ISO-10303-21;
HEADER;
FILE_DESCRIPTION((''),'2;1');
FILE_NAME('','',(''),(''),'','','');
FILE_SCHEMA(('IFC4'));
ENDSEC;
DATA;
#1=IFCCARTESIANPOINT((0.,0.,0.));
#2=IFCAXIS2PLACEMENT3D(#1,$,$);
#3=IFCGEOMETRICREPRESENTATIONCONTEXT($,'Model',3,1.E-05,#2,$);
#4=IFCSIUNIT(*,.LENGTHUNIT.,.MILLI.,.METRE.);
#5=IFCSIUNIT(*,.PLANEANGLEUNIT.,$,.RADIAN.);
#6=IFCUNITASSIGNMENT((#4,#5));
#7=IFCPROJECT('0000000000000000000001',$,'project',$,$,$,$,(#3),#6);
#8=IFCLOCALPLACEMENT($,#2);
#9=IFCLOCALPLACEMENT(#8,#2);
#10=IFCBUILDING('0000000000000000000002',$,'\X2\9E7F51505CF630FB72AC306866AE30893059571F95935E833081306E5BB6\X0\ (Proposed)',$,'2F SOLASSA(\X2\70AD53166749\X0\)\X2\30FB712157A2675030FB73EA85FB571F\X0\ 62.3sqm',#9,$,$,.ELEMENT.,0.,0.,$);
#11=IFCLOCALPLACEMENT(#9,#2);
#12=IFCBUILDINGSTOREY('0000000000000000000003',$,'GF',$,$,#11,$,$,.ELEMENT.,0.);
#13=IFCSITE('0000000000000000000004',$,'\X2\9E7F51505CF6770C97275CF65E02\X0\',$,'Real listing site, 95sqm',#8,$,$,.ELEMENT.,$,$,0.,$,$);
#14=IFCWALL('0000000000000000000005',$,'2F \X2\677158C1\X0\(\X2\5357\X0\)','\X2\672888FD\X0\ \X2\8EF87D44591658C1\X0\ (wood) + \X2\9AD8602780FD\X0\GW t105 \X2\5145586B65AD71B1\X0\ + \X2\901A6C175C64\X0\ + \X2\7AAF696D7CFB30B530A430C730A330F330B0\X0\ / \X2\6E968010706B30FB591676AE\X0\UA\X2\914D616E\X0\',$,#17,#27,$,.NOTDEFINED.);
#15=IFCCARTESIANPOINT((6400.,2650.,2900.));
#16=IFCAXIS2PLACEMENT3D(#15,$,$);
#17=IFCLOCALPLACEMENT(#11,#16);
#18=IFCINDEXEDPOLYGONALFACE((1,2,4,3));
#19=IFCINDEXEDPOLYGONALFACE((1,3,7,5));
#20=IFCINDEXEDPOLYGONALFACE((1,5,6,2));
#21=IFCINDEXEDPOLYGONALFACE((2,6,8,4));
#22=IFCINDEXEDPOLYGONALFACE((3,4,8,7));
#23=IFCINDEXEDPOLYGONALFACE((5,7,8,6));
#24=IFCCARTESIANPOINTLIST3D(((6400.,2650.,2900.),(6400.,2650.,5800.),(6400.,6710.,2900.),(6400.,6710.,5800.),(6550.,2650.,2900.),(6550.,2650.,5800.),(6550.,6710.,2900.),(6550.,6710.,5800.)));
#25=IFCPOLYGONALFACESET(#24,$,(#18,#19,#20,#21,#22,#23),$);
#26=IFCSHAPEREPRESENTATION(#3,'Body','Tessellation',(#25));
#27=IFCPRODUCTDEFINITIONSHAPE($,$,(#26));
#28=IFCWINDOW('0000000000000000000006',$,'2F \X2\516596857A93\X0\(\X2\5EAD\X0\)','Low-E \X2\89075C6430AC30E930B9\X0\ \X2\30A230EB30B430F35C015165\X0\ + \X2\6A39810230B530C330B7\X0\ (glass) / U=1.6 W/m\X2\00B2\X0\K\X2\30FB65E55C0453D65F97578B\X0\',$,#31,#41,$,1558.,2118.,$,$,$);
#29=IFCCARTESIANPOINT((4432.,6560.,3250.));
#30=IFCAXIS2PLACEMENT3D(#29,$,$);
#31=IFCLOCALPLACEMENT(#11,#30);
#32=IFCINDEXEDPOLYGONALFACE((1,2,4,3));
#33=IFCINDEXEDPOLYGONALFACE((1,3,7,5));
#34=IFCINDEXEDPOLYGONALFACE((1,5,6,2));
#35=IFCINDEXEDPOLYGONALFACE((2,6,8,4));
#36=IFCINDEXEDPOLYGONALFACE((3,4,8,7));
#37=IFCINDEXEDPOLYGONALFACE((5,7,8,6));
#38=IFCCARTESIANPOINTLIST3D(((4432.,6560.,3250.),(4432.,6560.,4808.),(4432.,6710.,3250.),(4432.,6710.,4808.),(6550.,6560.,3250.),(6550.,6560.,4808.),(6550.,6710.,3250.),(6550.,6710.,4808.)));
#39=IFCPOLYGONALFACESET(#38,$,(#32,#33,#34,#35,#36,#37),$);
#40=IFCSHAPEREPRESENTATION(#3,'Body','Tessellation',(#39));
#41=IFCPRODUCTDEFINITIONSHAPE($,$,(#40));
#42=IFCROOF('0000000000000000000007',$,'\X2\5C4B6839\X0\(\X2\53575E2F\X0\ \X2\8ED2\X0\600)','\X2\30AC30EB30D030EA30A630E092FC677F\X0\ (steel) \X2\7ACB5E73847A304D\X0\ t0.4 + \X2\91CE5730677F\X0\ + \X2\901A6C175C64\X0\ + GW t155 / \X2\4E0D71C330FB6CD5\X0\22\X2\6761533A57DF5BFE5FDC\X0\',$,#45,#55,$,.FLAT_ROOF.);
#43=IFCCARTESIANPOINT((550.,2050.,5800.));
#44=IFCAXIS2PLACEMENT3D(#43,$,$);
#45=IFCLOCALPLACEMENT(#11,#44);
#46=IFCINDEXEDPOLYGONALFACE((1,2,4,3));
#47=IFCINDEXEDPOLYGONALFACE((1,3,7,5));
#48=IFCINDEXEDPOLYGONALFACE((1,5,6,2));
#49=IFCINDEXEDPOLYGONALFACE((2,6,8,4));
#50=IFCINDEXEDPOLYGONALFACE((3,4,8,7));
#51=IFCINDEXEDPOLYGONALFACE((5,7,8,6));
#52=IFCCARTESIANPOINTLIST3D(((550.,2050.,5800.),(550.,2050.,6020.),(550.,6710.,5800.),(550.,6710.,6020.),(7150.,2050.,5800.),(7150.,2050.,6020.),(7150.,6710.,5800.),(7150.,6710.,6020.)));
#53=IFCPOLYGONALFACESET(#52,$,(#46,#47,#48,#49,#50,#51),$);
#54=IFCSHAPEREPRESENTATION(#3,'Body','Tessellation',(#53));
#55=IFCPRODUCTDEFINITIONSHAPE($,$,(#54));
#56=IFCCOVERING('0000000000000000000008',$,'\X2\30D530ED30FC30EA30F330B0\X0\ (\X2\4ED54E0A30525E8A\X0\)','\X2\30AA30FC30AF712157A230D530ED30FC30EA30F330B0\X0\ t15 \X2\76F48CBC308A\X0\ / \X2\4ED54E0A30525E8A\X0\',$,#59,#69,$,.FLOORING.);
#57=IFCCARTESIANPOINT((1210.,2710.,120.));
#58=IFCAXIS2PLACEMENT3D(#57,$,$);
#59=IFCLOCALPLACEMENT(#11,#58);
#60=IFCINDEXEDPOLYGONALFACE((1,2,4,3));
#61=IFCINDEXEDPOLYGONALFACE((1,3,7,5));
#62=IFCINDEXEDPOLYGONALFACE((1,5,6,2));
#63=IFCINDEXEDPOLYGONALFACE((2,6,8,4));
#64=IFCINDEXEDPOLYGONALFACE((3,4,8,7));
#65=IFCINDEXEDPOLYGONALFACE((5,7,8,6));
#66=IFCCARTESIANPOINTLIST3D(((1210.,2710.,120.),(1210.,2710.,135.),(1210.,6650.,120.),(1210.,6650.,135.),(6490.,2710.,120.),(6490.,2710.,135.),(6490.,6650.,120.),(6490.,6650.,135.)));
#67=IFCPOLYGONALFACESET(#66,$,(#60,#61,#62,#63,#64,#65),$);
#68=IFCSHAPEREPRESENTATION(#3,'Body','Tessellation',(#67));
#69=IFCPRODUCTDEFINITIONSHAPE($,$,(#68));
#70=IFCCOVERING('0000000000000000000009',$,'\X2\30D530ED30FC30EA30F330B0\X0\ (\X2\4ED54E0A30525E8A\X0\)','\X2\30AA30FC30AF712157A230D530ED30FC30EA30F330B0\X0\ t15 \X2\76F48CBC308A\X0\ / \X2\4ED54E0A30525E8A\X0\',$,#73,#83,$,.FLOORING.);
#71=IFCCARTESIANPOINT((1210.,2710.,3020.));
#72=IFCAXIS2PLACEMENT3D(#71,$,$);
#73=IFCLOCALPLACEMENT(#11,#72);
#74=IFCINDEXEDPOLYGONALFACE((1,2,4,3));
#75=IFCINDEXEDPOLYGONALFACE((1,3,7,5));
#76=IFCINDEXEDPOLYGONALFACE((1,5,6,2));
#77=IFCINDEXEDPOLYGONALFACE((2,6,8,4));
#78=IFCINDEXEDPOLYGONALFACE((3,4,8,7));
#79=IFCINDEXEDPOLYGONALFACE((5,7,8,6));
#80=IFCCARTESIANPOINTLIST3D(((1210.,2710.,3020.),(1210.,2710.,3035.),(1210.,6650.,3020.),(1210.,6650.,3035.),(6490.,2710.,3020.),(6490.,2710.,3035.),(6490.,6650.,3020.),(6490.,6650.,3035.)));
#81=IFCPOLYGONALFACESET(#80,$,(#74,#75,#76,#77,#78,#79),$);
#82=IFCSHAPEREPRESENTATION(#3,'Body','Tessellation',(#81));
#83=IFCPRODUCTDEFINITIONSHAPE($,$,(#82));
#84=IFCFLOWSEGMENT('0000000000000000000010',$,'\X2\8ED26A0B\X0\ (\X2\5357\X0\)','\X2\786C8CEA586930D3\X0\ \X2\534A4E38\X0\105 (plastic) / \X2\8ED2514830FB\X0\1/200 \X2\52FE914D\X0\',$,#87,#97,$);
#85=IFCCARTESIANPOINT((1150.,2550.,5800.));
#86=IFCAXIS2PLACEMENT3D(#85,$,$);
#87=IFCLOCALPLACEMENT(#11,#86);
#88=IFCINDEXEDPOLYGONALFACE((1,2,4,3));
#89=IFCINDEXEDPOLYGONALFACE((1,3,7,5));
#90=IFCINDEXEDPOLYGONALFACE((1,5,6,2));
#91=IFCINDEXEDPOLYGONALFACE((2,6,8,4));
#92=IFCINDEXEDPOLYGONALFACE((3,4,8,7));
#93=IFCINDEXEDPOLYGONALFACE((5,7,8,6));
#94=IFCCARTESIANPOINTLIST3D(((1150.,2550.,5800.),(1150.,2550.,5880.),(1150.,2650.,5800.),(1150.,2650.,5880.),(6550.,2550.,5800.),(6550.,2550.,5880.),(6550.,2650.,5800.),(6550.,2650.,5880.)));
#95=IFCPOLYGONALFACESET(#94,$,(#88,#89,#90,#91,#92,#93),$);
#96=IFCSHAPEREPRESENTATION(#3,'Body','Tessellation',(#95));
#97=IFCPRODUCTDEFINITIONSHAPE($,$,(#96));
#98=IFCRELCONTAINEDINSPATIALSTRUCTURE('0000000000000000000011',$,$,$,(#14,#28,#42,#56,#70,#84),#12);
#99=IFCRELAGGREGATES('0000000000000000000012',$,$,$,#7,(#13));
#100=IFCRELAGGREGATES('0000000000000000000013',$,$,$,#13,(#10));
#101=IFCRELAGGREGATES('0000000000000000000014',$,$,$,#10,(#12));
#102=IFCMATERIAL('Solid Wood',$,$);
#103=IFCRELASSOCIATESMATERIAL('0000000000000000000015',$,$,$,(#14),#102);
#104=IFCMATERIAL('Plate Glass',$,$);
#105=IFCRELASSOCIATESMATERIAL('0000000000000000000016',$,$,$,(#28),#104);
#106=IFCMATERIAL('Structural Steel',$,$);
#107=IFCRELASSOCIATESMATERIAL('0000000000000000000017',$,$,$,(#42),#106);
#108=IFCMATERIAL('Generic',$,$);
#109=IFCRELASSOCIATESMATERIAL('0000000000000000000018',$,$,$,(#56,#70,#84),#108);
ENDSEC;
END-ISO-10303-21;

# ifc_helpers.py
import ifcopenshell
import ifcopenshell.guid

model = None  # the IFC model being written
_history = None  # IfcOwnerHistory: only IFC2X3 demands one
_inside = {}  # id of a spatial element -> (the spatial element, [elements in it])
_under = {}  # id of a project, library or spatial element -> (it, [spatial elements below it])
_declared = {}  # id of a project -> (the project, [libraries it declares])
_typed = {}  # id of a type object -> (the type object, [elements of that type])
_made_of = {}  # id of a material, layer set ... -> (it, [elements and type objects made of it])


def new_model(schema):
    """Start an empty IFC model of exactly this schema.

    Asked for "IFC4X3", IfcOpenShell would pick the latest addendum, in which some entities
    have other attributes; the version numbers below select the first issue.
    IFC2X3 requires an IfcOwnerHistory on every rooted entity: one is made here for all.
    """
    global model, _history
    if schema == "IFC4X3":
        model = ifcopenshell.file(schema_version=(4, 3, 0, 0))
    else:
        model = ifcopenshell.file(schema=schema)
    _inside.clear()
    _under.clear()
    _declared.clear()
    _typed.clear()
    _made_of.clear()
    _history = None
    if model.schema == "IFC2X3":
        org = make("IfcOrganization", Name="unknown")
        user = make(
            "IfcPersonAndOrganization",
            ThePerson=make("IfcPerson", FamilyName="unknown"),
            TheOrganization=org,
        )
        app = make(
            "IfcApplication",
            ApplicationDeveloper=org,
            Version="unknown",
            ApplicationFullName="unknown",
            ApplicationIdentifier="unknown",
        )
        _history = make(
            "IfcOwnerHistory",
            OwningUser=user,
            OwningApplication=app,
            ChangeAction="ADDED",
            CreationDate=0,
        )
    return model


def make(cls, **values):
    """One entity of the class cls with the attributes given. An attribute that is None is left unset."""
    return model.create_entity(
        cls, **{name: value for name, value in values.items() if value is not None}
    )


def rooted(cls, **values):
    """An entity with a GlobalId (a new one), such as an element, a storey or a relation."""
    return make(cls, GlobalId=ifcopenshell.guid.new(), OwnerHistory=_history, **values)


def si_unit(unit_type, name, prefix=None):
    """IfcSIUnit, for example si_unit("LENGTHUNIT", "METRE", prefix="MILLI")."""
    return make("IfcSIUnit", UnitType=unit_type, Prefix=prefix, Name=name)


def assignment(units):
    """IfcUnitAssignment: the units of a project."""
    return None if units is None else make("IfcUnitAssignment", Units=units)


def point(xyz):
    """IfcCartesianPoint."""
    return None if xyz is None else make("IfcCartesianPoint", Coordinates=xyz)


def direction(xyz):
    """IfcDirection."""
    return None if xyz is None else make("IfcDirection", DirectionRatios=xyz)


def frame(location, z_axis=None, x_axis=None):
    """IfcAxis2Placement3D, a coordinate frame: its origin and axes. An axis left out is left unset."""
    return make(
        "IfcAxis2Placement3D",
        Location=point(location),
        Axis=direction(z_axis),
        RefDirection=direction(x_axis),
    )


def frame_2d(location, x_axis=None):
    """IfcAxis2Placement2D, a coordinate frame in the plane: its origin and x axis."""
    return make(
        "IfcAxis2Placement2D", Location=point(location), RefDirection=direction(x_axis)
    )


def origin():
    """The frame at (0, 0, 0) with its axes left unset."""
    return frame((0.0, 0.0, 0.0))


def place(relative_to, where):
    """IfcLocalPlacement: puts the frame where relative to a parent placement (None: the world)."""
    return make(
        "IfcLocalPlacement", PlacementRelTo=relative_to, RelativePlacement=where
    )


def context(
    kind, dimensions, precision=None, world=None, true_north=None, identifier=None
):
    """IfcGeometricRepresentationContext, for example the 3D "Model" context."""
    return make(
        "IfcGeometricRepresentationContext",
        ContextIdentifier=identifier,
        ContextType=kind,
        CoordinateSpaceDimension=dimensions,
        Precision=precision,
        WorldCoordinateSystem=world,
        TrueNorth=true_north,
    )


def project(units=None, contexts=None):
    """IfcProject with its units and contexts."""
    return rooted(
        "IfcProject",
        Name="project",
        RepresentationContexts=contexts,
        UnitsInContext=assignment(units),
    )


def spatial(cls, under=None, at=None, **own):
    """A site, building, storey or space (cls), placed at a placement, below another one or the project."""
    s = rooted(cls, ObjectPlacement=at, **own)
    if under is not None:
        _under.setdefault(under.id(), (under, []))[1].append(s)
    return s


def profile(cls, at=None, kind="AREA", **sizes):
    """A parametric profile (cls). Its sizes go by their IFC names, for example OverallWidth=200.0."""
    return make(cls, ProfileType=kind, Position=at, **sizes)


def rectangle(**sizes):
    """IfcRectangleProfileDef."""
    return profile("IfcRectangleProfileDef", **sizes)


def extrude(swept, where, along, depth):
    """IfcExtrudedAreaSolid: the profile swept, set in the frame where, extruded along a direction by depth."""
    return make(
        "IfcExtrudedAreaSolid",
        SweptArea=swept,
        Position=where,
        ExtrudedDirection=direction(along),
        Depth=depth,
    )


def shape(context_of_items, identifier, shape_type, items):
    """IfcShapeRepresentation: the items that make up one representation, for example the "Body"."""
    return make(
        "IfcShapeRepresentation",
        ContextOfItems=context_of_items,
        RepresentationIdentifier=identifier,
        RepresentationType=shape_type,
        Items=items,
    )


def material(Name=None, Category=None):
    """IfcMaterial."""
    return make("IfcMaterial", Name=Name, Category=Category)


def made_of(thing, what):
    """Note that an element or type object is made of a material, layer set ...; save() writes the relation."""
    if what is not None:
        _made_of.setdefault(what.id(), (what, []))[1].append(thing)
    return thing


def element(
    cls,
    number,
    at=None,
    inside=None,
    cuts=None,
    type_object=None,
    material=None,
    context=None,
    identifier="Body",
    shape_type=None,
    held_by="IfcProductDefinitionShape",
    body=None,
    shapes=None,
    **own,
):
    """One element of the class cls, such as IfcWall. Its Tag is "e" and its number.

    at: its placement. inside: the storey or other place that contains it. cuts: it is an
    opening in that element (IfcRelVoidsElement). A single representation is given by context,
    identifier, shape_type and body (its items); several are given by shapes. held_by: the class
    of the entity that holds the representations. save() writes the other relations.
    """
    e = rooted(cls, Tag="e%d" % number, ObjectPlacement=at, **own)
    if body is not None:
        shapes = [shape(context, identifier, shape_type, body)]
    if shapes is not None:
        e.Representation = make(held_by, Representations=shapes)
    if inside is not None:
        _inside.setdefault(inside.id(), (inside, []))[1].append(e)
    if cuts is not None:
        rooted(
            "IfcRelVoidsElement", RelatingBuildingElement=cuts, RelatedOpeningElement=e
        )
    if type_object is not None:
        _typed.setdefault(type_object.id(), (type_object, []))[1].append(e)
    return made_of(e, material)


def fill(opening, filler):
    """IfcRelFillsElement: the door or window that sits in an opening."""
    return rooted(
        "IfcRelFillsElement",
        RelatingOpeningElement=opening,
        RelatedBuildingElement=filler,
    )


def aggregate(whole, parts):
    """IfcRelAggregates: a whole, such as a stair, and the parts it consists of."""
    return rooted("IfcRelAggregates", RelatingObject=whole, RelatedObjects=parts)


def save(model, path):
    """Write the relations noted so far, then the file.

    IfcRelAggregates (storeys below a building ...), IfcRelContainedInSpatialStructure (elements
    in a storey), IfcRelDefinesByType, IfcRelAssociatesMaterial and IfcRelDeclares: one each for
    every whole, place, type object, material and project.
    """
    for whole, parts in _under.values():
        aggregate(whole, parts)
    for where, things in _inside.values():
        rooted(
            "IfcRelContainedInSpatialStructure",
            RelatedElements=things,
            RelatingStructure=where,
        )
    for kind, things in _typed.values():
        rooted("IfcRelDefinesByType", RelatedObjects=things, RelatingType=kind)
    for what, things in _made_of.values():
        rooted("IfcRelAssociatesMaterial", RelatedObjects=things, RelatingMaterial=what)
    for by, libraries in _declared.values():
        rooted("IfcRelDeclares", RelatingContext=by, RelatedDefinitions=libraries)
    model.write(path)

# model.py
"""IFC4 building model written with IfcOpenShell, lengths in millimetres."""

from ifc_helpers import new_model, si_unit, frame, frame_2d, origin, place, context, project, spatial, rectangle, extrude, material, element, fill, save


model = new_model("IFC4")

# Units and contexts
model_context = context("Model", 3, precision=1e-05, world=origin())
ifc_project = project(units=[si_unit("LENGTHUNIT", "METRE", prefix="MILLI"), si_unit("PLANEANGLEUNIT", "RADIAN")], contexts=[model_context])

# Site, building, storey
site_placement = place(None, origin())
site = spatial("IfcSite", under=ifc_project, at=site_placement, Name="鹿児島県霧島市", ObjectType="Real listing site, 95sqm", CompositionType="ELEMENT", RefElevation=0.0)
building_placement = place(site_placement, origin())
building = spatial("IfcBuilding", under=site, at=building_placement, Name="鹿児島・犬と暮らす土間広めの家 (Proposed)", ObjectType="2F SOLASSA(炭化杉)・無垢材・珪藻土 62.3sqm", CompositionType="ELEMENT", ElevationOfRefHeight=0.0, ElevationOfTerrain=0.0)
storey_placement = place(building_placement, origin())
storey = spatial("IfcBuildingStorey", under=building, at=storey_placement, Name="GF", CompositionType="ELEMENT", Elevation=0.0)

# Shared definitions
ifc_material_1 = material(Name="Solid Wood")

# Wall, opening, window
ifc_material_2 = material(Name="Plate Glass")
wall_1_placement = place(storey_placement, frame((6400.0, 2650.0, 2900.0)))
wall_1 = element("IfcWall", 1, at=wall_1_placement, inside=storey, material=ifc_material_1, Name="2F 東壁(南)", Description="木製 軸組外壁 (wood) + 高性能GW t105 充填断熱 + 通気層 + 窯業系サイディング / 準耐火・外皮UA配慮", PredefinedType="NOTDEFINED", context=model_context, shape_type="SweptSolid", body=[
    extrude(rectangle(XDim=150.0, YDim=4060.0, at=frame_2d((75.0, 2030.0))), frame((6400.0, 2650.0, 2900.0)), (0.0, 0.0, 1.0), 2900.0),
])
opening_1_placement = place(storey_placement, frame((4432.0, 6560.0, 3250.0)))
opening_1 = element("IfcOpeningElement", 2, at=opening_1_placement, cuts=wall_1, PredefinedType="NOTDEFINED", context=model_context, shape_type="SweptSolid", body=[
    extrude(rectangle(XDim=2118.0, YDim=150.0, at=frame_2d((1059.0, 75.0))), frame((4432.0, 6560.0, 3250.0)), (0.0, 0.0, 1.0), 1558.0),
])
window_1_placement = place(storey_placement, frame((4432.0, 6560.0, 3250.0)))
window_1 = element("IfcWindow", 3, at=window_1_placement, inside=storey, material=ifc_material_2, Name="2F 入隅窓(庭)", Description="Low-E 複層ガラス アルゴン封入 + 樹脂サッシ (glass) / U=1.6 W/m²K・日射取得型", OverallHeight=1558.0, OverallWidth=2118.0, context=model_context, shape_type="SweptSolid", body=[
    extrude(rectangle(XDim=2118.0, YDim=150.0, at=frame_2d((1059.0, 75.0))), frame((4432.0, 6560.0, 3250.0)), (0.0, 0.0, 1.0), 1558.0),
])
fill(opening_1, window_1)

# Roof
ifc_material_3 = material(Name="Structural Steel")
for number, where, name in (
    (4, (550.0, 2050.0, 5800.0), "屋根(南帯 軒600)"),
):
    element("IfcRoof", number, at=place(storey_placement, frame(where)), inside=storey, material=ifc_material_3, Name=name, Description="ガルバリウム鋼板 (steel) 立平葺き t0.4 + 野地板 + 通気層 + GW t155 / 不燃・法22条区域対応", PredefinedType="FLAT_ROOF", context=model_context, shape_type="SweptSolid", body=[
        extrude(rectangle(XDim=6600.0, YDim=4660.0, at=frame_2d((3300.0, 2330.0))), frame((550.0, 2050.0, 5800.0)), (0.0, 0.0, 1.0), 220.0),
    ])

# Coverings
ifc_material_4 = material(Name="Generic")
covering_1_placement = place(storey_placement, frame((1210.0, 2710.0, 120.0)))
element("IfcCovering", 5, at=covering_1_placement, inside=storey, material=ifc_material_4, Name="フローリング (仕上げ床)", Description="オーク無垢フローリング t15 直貼り / 仕上げ床", PredefinedType="FLOORING", context=model_context, shape_type="SweptSolid", body=[
    extrude(rectangle(XDim=5280.0, YDim=3940.0, at=frame_2d((2640.0, 1970.0))), frame((1210.0, 2710.0, 120.0)), (0.0, 0.0, 1.0), 15.0),
])
covering_2_placement = place(storey_placement, frame((1210.0, 2710.0, 3020.0)))
element("IfcCovering", 6, at=covering_2_placement, inside=storey, material=ifc_material_4, Name="フローリング (仕上げ床)", Description="オーク無垢フローリング t15 直貼り / 仕上げ床", PredefinedType="FLOORING", context=model_context, shape_type="SweptSolid", body=[
    extrude(rectangle(XDim=5280.0, YDim=3940.0, at=frame_2d((2640.0, 1970.0))), frame((1210.0, 2710.0, 3020.0)), (0.0, 0.0, 1.0), 15.0),
])

# Flow segment
flow_segment_placement = place(storey_placement, frame((1150.0, 2550.0, 5800.0)))
element("IfcFlowSegment", 7, at=flow_segment_placement, inside=storey, material=ifc_material_4, Name="軒樋 (南)", Description="硬質塩ビ 半丸105 (plastic) / 軒先・1/200 勾配", context=model_context, shape_type="SweptSolid", body=[
    extrude(rectangle(XDim=5400.0, YDim=100.0, at=frame_2d((2700.0, 50.0))), frame((1150.0, 2550.0, 5800.0)), (0.0, 0.0, 1.0), 80.0),
])

save(model, "model.ifc")
